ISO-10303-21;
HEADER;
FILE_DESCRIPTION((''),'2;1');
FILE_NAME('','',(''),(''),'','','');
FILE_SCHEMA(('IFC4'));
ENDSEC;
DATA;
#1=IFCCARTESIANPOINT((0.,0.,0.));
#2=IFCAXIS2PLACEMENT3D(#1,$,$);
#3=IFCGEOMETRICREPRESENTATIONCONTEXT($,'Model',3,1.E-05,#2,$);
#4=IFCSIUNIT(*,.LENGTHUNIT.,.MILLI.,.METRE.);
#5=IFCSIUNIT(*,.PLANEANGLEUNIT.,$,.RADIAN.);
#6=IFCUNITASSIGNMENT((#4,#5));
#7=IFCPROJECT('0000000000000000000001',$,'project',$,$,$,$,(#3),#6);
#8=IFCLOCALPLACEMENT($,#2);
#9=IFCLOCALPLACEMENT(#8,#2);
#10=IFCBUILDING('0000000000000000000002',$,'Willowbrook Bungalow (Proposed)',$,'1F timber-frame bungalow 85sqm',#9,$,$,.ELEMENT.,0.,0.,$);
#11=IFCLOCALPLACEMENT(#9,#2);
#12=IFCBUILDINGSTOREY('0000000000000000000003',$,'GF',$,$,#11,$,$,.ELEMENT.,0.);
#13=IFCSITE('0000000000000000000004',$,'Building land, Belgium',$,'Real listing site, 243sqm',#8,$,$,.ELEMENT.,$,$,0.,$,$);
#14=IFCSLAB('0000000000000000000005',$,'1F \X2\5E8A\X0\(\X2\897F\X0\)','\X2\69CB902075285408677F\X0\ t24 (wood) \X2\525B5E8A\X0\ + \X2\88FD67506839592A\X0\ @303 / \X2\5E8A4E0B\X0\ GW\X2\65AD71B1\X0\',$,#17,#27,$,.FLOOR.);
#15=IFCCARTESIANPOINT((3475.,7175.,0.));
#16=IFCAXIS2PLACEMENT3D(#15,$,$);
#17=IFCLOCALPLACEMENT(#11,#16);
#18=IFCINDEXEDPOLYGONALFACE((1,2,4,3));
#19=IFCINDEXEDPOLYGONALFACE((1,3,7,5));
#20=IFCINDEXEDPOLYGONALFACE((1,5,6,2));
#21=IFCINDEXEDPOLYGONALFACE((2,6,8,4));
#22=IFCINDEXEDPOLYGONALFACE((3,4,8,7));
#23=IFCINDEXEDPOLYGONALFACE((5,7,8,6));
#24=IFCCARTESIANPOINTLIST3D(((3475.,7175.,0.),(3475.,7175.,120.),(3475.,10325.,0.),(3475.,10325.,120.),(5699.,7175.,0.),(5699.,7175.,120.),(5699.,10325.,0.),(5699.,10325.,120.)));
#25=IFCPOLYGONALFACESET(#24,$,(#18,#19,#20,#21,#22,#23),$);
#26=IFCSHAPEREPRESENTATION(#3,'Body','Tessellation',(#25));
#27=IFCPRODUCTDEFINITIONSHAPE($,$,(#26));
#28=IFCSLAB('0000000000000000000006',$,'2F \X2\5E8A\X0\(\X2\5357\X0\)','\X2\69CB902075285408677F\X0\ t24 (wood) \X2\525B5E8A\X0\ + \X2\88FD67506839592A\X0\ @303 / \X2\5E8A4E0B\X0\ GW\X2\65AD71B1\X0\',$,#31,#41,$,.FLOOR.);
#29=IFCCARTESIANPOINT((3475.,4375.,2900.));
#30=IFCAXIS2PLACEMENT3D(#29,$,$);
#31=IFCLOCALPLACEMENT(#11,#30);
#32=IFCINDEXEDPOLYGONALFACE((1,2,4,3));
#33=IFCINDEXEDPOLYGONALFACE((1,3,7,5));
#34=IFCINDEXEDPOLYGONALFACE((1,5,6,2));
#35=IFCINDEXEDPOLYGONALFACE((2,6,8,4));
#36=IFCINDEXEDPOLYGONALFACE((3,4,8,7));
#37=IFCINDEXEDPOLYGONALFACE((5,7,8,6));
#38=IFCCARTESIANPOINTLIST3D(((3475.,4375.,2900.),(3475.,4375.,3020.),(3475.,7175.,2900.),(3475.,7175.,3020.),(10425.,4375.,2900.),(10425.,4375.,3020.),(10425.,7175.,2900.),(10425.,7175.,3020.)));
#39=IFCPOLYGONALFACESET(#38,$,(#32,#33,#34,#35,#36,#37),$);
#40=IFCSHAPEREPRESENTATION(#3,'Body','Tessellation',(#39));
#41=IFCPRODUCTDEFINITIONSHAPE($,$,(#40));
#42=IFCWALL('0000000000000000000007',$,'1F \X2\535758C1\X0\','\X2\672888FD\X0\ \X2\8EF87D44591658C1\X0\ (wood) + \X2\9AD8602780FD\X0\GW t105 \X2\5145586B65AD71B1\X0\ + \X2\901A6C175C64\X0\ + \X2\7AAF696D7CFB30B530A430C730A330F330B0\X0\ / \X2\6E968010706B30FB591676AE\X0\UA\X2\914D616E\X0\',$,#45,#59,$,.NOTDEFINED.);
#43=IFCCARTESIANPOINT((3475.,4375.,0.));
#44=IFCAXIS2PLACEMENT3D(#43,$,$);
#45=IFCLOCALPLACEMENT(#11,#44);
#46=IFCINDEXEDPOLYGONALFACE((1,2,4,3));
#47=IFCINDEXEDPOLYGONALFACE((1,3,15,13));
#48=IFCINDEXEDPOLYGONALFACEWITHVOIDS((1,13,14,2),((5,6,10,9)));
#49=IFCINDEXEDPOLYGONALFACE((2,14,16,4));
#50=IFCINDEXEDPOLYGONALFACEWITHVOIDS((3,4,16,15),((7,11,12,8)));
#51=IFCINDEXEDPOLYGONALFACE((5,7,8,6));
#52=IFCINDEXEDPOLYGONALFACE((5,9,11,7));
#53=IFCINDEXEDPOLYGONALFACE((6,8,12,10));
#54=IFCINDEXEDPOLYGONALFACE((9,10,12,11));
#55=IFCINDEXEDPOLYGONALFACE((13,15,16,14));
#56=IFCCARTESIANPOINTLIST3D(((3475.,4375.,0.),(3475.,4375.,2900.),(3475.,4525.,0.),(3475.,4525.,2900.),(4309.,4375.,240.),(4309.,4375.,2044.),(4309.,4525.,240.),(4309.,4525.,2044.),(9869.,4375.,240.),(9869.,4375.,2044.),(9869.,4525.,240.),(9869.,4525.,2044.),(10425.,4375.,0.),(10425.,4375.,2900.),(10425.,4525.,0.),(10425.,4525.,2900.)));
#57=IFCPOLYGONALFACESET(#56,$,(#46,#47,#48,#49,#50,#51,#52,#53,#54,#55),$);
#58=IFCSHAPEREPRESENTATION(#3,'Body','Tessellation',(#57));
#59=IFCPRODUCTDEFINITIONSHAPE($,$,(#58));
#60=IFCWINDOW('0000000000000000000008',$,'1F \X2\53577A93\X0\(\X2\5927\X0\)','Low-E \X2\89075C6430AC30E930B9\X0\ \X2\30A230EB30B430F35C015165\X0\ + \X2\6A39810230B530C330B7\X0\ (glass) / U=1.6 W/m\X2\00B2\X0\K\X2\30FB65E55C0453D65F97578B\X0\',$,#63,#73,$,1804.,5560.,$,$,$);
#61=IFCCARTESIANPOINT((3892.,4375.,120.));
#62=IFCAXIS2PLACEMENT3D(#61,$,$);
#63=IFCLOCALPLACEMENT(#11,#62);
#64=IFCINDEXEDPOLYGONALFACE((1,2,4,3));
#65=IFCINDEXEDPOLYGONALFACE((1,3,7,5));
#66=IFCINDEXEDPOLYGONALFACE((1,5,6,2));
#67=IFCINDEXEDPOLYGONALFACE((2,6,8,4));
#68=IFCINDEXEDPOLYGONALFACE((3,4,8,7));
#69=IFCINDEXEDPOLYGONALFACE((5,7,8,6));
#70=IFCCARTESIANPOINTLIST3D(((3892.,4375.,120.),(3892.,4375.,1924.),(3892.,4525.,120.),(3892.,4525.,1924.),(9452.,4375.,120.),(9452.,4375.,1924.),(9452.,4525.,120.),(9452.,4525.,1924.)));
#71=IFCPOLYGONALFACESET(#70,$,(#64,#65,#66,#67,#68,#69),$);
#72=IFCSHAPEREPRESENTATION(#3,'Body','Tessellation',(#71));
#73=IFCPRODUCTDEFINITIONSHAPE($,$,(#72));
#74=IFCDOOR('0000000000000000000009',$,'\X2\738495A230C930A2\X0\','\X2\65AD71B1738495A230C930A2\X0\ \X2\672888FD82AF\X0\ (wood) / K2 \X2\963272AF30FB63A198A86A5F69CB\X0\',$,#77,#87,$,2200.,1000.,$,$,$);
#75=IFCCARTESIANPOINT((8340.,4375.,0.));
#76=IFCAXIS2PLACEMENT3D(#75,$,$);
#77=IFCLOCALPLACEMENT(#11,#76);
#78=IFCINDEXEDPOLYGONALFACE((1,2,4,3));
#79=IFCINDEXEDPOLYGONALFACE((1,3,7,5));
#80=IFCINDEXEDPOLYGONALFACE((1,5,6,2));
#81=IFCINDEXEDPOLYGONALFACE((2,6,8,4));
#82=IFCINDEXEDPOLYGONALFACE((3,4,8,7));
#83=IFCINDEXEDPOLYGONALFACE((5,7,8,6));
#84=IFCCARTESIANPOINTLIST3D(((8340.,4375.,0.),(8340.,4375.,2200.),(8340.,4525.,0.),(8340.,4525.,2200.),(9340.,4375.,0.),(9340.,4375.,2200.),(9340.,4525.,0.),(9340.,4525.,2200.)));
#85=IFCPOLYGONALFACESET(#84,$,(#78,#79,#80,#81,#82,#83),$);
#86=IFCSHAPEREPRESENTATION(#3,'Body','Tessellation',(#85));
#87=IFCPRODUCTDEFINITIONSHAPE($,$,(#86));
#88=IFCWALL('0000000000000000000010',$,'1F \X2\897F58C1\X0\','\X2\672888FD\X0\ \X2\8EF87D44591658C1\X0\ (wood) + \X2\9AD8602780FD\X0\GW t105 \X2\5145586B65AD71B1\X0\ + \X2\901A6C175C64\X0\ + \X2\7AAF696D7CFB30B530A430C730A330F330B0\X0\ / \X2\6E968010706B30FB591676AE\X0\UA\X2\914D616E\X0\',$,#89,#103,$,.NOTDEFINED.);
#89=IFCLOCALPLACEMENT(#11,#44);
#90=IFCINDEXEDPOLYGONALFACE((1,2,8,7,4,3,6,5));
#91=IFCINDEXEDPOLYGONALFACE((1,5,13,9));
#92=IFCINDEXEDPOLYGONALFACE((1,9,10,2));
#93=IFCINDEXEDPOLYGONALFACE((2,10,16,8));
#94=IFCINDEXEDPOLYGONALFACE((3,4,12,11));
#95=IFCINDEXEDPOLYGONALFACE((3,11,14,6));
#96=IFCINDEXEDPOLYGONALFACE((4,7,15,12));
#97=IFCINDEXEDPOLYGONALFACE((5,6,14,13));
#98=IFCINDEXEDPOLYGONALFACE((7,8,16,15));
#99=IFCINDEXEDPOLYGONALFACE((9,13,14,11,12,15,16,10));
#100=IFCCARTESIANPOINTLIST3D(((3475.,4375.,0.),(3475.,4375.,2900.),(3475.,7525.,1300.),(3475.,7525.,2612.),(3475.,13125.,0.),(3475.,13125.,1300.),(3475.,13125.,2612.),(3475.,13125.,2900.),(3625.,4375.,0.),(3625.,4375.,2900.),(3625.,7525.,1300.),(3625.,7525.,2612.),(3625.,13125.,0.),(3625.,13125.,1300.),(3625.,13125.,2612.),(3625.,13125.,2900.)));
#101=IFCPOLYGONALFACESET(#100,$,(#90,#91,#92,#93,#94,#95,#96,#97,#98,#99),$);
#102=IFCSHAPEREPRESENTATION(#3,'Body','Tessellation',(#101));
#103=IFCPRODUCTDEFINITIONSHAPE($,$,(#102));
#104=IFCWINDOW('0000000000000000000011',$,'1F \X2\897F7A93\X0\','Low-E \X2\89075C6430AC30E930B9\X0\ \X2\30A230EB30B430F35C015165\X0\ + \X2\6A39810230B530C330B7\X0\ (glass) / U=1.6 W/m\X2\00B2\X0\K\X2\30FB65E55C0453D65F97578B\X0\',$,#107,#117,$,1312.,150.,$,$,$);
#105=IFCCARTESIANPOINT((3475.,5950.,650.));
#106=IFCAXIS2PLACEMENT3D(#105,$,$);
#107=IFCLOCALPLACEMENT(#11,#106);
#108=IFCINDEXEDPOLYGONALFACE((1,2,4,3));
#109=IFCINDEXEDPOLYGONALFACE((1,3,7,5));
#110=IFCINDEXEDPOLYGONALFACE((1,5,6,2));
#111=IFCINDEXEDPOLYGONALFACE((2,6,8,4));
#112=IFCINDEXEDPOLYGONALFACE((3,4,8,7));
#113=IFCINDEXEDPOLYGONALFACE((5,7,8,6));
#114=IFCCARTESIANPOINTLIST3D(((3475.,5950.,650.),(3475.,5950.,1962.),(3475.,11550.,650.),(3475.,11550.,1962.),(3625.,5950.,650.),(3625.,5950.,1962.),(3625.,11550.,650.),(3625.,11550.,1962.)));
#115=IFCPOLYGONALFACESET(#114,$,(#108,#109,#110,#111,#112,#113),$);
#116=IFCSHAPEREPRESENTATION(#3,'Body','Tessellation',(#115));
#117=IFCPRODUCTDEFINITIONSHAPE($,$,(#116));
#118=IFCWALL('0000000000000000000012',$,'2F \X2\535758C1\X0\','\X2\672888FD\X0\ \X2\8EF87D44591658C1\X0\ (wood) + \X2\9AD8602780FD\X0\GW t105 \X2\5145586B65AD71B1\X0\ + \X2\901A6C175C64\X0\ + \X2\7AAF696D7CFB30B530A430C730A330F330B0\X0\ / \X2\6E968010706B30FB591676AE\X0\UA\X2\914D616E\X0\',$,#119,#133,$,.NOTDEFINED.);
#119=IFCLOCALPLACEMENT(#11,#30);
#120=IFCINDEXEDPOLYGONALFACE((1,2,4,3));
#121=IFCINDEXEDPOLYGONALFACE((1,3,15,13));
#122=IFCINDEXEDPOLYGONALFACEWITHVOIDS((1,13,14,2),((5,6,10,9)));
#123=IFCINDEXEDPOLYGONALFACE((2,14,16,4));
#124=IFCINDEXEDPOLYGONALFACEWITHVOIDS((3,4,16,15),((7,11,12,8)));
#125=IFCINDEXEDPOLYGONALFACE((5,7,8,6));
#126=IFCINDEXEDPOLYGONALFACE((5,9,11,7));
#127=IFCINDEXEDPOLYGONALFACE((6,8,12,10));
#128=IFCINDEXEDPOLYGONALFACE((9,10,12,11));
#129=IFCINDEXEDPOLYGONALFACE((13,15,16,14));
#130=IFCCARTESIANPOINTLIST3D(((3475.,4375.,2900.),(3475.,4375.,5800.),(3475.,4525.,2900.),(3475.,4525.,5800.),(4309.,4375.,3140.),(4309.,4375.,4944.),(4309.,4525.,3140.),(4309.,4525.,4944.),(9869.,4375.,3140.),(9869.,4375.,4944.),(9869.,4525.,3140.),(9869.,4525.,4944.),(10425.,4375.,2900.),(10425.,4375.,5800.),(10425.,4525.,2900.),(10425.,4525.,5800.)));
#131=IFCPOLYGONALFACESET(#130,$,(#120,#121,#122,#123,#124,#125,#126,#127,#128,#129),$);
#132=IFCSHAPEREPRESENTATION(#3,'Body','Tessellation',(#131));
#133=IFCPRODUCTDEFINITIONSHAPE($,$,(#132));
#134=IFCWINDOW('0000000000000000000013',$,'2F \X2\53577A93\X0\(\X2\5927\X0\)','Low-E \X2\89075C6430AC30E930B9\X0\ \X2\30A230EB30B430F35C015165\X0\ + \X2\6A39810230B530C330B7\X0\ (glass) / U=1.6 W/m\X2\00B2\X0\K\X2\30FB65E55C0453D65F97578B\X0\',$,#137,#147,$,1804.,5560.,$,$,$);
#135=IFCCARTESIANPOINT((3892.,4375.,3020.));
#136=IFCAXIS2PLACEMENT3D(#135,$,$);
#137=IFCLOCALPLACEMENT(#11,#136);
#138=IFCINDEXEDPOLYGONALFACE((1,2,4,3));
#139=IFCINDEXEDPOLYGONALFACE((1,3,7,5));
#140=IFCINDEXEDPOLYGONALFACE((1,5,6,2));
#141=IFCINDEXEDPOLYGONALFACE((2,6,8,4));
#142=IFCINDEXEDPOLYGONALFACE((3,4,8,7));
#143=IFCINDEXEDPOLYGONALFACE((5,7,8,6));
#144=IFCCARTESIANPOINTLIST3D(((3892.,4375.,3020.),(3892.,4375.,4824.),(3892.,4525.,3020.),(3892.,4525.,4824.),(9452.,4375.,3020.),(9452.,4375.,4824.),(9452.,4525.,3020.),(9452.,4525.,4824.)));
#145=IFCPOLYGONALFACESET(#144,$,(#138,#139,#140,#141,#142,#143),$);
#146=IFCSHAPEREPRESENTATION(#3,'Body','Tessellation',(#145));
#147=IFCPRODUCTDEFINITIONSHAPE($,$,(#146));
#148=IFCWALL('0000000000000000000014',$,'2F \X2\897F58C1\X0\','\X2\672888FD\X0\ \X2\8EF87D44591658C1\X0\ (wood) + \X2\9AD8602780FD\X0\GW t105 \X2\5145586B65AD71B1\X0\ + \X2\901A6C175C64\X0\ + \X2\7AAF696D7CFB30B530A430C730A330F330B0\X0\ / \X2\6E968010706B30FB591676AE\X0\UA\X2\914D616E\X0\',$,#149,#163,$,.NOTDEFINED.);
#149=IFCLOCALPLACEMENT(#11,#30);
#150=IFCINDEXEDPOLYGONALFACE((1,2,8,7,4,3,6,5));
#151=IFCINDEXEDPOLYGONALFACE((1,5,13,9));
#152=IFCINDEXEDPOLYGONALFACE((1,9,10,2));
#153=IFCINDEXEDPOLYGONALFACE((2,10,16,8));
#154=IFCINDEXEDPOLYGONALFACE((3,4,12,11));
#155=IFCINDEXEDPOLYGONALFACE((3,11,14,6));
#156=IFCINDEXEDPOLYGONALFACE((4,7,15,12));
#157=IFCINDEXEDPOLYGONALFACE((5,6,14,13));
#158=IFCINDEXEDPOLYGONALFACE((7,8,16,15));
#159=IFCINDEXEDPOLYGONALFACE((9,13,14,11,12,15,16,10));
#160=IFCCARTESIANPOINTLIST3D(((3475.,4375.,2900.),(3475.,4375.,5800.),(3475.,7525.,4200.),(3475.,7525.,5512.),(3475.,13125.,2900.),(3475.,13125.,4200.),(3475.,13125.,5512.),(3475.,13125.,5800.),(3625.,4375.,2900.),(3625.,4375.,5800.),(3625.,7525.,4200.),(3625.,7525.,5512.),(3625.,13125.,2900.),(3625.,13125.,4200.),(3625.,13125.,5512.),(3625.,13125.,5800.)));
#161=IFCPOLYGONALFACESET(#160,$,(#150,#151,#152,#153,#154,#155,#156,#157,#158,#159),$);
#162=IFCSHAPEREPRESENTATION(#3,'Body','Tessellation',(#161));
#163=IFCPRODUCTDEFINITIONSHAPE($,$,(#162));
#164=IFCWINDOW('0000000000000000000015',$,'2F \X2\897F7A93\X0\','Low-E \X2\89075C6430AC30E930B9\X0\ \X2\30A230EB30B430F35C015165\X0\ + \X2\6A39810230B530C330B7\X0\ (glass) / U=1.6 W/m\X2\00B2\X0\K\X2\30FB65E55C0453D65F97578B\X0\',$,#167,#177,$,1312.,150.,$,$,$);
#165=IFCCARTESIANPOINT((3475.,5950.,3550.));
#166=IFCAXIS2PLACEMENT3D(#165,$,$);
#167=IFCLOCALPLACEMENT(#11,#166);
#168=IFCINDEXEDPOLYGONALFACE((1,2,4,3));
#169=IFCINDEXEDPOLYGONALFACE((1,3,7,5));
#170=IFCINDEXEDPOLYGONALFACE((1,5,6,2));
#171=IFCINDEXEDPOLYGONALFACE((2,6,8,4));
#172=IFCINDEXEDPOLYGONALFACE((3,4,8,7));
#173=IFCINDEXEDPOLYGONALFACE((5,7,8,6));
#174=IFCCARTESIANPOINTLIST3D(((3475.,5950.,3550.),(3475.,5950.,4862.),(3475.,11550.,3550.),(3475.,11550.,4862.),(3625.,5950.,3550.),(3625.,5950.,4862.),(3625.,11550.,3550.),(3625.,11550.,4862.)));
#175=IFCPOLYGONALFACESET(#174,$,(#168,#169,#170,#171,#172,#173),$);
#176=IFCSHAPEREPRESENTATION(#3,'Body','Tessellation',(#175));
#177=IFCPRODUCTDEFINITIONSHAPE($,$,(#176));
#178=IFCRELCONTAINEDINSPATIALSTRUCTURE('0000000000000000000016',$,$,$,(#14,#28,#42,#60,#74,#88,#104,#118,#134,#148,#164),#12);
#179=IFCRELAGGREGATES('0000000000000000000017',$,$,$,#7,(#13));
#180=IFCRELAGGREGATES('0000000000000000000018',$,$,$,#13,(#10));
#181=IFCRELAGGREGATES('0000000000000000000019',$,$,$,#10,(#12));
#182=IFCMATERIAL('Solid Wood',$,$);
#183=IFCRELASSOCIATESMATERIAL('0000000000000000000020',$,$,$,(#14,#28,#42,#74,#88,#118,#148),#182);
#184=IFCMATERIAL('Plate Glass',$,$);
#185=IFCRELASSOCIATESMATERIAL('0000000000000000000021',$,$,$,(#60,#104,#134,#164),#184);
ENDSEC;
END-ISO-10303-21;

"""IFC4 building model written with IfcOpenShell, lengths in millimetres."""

from ifc_helpers import new_model, si_unit, frame, frame_2d, origin, place, context, project, spatial, rectangle, extrude, material, element, fill, save


model = new_model("IFC4")

# Units and contexts
model_context = context("Model", 3, precision=1e-05, world=origin())
ifc_project = project(units=[si_unit("LENGTHUNIT", "METRE", prefix="MILLI"), si_unit("PLANEANGLEUNIT", "RADIAN")], contexts=[model_context])

# Site, building, storey
site_placement = place(None, origin())
site = spatial("IfcSite", under=ifc_project, at=site_placement, Name="Building land, Belgium", ObjectType="Real listing site, 243sqm", CompositionType="ELEMENT", RefElevation=0.0)
building_placement = place(site_placement, origin())
building = spatial("IfcBuilding", under=site, at=building_placement, Name="Willowbrook Bungalow (Proposed)", ObjectType="1F timber-frame bungalow 85sqm", CompositionType="ELEMENT", ElevationOfRefHeight=0.0, ElevationOfTerrain=0.0)
storey_placement = place(building_placement, origin())
storey = spatial("IfcBuildingStorey", under=building, at=storey_placement, Name="GF", CompositionType="ELEMENT", Elevation=0.0)

# Slabs
ifc_material_1 = material(Name="Solid Wood")
slab_1_placement = place(storey_placement, frame((3475.0, 7175.0, 0.0)))
element("IfcSlab", 1, at=slab_1_placement, inside=storey, material=ifc_material_1, Name="1F 床(西)", Description="構造用合板 t24 (wood) 剛床 + 製材根太 @303 / 床下 GW断熱", PredefinedType="FLOOR", context=model_context, shape_type="SweptSolid", body=[
    extrude(rectangle(XDim=2224.0, YDim=3150.0, at=frame_2d((1112.0, 1575.0))), frame((3475.0, 7175.0, 0.0)), (0.0, 0.0, 1.0), 120.0),
])
slab_2_placement = place(storey_placement, frame((3475.0, 4375.0, 2900.0)))
element("IfcSlab", 2, at=slab_2_placement, inside=storey, material=ifc_material_1, Name="2F 床(南)", Description="構造用合板 t24 (wood) 剛床 + 製材根太 @303 / 床下 GW断熱", PredefinedType="FLOOR", context=model_context, shape_type="SweptSolid", body=[
    extrude(rectangle(XDim=6950.0, YDim=2800.0, at=frame_2d((3475.0, 1400.0))), frame((3475.0, 4375.0, 2900.0)), (0.0, 0.0, 1.0), 120.0),
])

# Wall, openings, window, door
wall_1_placement = place(storey_placement, frame((3475.0, 4375.0, 0.0)))
wall_1 = element("IfcWall", 3, at=wall_1_placement, inside=storey, material=ifc_material_1, Name="1F 南壁", Description="木製 軸組外壁 (wood) + 高性能GW t105 充填断熱 + 通気層 + 窯業系サイディング / 準耐火・外皮UA配慮", PredefinedType="NOTDEFINED", context=model_context, shape_type="SweptSolid", body=[
    extrude(rectangle(XDim=6950.0, YDim=150.0, at=frame_2d((3475.0, 75.0))), frame((3475.0, 4375.0, 0.0)), (0.0, 0.0, 1.0), 2900.0),
])
opening_1_placement = place(storey_placement, frame((3892.0, 4375.0, 120.0)))
opening_1 = element("IfcOpeningElement", 4, at=opening_1_placement, cuts=wall_1, PredefinedType="NOTDEFINED", context=model_context, shape_type="SweptSolid", body=[
    extrude(rectangle(XDim=5560.0, YDim=150.0, at=frame_2d((2780.0, 75.0))), frame((3892.0, 4375.0, 120.0)), (0.0, 0.0, 1.0), 1804.0),
])
opening_2_placement = place(storey_placement, frame((8340.0, 4375.0, 0.0)))
opening_2 = element("IfcOpeningElement", 5, at=opening_2_placement, cuts=wall_1, PredefinedType="NOTDEFINED", context=model_context, shape_type="SweptSolid", body=[
    extrude(rectangle(XDim=1000.0, YDim=150.0, at=frame_2d((500.0, 75.0))), frame((8340.0, 4375.0, 0.0)), (0.0, 0.0, 1.0), 2200.0),
])
ifc_material_2 = material(Name="Plate Glass")
window_1_placement = place(storey_placement, frame((3892.0, 4375.0, 120.0)))
window_1 = element("IfcWindow", 6, at=window_1_placement, inside=storey, material=ifc_material_2, Name="1F 南窓(大)", Description="Low-E 複層ガラス アルゴン封入 + 樹脂サッシ (glass) / U=1.6 W/m²K・日射取得型", OverallHeight=1804.0, OverallWidth=5560.0, context=model_context, shape_type="SweptSolid", body=[
    extrude(rectangle(XDim=5560.0, YDim=150.0, at=frame_2d((2780.0, 75.0))), frame((3892.0, 4375.0, 120.0)), (0.0, 0.0, 1.0), 1804.0),
])
fill(opening_1, window_1)
door_placement = place(storey_placement, frame((8340.0, 4375.0, 0.0)))
door = element("IfcDoor", 7, at=door_placement, inside=storey, material=ifc_material_1, Name="玄関ドア", Description="断熱玄関ドア 木製芯 (wood) / K2 防犯・採風機構", OverallHeight=2200.0, OverallWidth=1000.0, context=model_context, shape_type="SweptSolid", body=[
    extrude(rectangle(XDim=1000.0, YDim=150.0, at=frame_2d((500.0, 75.0))), frame((8340.0, 4375.0, 0.0)), (0.0, 0.0, 1.0), 2200.0),
])
fill(opening_2, door)

# Walls, openings, windows
wall_2_placement = place(storey_placement, frame((3475.0, 4375.0, 0.0)))
wall_2 = element("IfcWall", 8, at=wall_2_placement, inside=storey, material=ifc_material_1, Name="1F 西壁", Description="木製 軸組外壁 (wood) + 高性能GW t105 充填断熱 + 通気層 + 窯業系サイディング / 準耐火・外皮UA配慮", PredefinedType="NOTDEFINED", context=model_context, shape_type="SweptSolid", body=[
    extrude(rectangle(XDim=150.0, YDim=8750.0, at=frame_2d((75.0, 4375.0))), frame((3475.0, 4375.0, 0.0)), (0.0, 0.0, 1.0), 2900.0),
])
opening_3_placement = place(storey_placement, frame((3475.0, 5950.0, 650.0)))
opening_3 = element("IfcOpeningElement", 9, at=opening_3_placement, cuts=wall_2, PredefinedType="NOTDEFINED", context=model_context, shape_type="SweptSolid", body=[
    extrude(rectangle(XDim=150.0, YDim=5600.0, at=frame_2d((75.0, 2800.0))), frame((3475.0, 5950.0, 650.0)), (0.0, 0.0, 1.0), 1312.0),
])
window_2_placement = place(storey_placement, frame((3475.0, 5950.0, 650.0)))
window_2 = element("IfcWindow", 10, at=window_2_placement, inside=storey, material=ifc_material_2, Name="1F 西窓", Description="Low-E 複層ガラス アルゴン封入 + 樹脂サッシ (glass) / U=1.6 W/m²K・日射取得型", OverallHeight=1312.0, OverallWidth=150.0, context=model_context, shape_type="SweptSolid", body=[
    extrude(rectangle(XDim=150.0, YDim=5600.0, at=frame_2d((75.0, 2800.0))), frame((3475.0, 5950.0, 650.0)), (0.0, 0.0, 1.0), 1312.0),
])
fill(opening_3, window_2)
wall_3_placement = place(storey_placement, frame((3475.0, 4375.0, 2900.0)))
wall_3 = element("IfcWall", 11, at=wall_3_placement, inside=storey, material=ifc_material_1, Name="2F 南壁", Description="木製 軸組外壁 (wood) + 高性能GW t105 充填断熱 + 通気層 + 窯業系サイディング / 準耐火・外皮UA配慮", PredefinedType="NOTDEFINED", context=model_context, shape_type="SweptSolid", body=[
    extrude(rectangle(XDim=6950.0, YDim=150.0, at=frame_2d((3475.0, 75.0))), frame((3475.0, 4375.0, 2900.0)), (0.0, 0.0, 1.0), 2900.0),
])
opening_4_placement = place(storey_placement, frame((3892.0, 4375.0, 3020.0)))
opening_4 = element("IfcOpeningElement", 12, at=opening_4_placement, cuts=wall_3, PredefinedType="NOTDEFINED", context=model_context, shape_type="SweptSolid", body=[
    extrude(rectangle(XDim=5560.0, YDim=150.0, at=frame_2d((2780.0, 75.0))), frame((3892.0, 4375.0, 3020.0)), (0.0, 0.0, 1.0), 1804.0),
])
window_3_placement = place(storey_placement, frame((3892.0, 4375.0, 3020.0)))
window_3 = element("IfcWindow", 13, at=window_3_placement, inside=storey, material=ifc_material_2, Name="2F 南窓(大)", Description="Low-E 複層ガラス アルゴン封入 + 樹脂サッシ (glass) / U=1.6 W/m²K・日射取得型", OverallHeight=1804.0, OverallWidth=5560.0, context=model_context, shape_type="SweptSolid", body=[
    extrude(rectangle(XDim=5560.0, YDim=150.0, at=frame_2d((2780.0, 75.0))), frame((3892.0, 4375.0, 3020.0)), (0.0, 0.0, 1.0), 1804.0),
])
fill(opening_4, window_3)
wall_4_placement = place(storey_placement, frame((3475.0, 4375.0, 2900.0)))
wall_4 = element("IfcWall", 14, at=wall_4_placement, inside=storey, material=ifc_material_1, Name="2F 西壁", Description="木製 軸組外壁 (wood) + 高性能GW t105 充填断熱 + 通気層 + 窯業系サイディング / 準耐火・外皮UA配慮", PredefinedType="NOTDEFINED", context=model_context, shape_type="SweptSolid", body=[
    extrude(rectangle(XDim=150.0, YDim=8750.0, at=frame_2d((75.0, 4375.0))), frame((3475.0, 4375.0, 2900.0)), (0.0, 0.0, 1.0), 2900.0),
])
opening_5_placement = place(storey_placement, frame((3475.0, 5950.0, 3550.0)))
opening_5 = element("IfcOpeningElement", 15, at=opening_5_placement, cuts=wall_4, PredefinedType="NOTDEFINED", context=model_context, shape_type="SweptSolid", body=[
    extrude(rectangle(XDim=150.0, YDim=5600.0, at=frame_2d((75.0, 2800.0))), frame((3475.0, 5950.0, 3550.0)), (0.0, 0.0, 1.0), 1312.0),
])
window_4_placement = place(storey_placement, frame((3475.0, 5950.0, 3550.0)))
window_4 = element("IfcWindow", 16, at=window_4_placement, inside=storey, material=ifc_material_2, Name="2F 西窓", Description="Low-E 複層ガラス アルゴン封入 + 樹脂サッシ (glass) / U=1.6 W/m²K・日射取得型", OverallHeight=1312.0, OverallWidth=150.0, context=model_context, shape_type="SweptSolid", body=[
    extrude(rectangle(XDim=150.0, YDim=5600.0, at=frame_2d((75.0, 2800.0))), frame((3475.0, 5950.0, 3550.0)), (0.0, 0.0, 1.0), 1312.0),
])
fill(opening_5, window_4)

save(model, "model.ifc")
